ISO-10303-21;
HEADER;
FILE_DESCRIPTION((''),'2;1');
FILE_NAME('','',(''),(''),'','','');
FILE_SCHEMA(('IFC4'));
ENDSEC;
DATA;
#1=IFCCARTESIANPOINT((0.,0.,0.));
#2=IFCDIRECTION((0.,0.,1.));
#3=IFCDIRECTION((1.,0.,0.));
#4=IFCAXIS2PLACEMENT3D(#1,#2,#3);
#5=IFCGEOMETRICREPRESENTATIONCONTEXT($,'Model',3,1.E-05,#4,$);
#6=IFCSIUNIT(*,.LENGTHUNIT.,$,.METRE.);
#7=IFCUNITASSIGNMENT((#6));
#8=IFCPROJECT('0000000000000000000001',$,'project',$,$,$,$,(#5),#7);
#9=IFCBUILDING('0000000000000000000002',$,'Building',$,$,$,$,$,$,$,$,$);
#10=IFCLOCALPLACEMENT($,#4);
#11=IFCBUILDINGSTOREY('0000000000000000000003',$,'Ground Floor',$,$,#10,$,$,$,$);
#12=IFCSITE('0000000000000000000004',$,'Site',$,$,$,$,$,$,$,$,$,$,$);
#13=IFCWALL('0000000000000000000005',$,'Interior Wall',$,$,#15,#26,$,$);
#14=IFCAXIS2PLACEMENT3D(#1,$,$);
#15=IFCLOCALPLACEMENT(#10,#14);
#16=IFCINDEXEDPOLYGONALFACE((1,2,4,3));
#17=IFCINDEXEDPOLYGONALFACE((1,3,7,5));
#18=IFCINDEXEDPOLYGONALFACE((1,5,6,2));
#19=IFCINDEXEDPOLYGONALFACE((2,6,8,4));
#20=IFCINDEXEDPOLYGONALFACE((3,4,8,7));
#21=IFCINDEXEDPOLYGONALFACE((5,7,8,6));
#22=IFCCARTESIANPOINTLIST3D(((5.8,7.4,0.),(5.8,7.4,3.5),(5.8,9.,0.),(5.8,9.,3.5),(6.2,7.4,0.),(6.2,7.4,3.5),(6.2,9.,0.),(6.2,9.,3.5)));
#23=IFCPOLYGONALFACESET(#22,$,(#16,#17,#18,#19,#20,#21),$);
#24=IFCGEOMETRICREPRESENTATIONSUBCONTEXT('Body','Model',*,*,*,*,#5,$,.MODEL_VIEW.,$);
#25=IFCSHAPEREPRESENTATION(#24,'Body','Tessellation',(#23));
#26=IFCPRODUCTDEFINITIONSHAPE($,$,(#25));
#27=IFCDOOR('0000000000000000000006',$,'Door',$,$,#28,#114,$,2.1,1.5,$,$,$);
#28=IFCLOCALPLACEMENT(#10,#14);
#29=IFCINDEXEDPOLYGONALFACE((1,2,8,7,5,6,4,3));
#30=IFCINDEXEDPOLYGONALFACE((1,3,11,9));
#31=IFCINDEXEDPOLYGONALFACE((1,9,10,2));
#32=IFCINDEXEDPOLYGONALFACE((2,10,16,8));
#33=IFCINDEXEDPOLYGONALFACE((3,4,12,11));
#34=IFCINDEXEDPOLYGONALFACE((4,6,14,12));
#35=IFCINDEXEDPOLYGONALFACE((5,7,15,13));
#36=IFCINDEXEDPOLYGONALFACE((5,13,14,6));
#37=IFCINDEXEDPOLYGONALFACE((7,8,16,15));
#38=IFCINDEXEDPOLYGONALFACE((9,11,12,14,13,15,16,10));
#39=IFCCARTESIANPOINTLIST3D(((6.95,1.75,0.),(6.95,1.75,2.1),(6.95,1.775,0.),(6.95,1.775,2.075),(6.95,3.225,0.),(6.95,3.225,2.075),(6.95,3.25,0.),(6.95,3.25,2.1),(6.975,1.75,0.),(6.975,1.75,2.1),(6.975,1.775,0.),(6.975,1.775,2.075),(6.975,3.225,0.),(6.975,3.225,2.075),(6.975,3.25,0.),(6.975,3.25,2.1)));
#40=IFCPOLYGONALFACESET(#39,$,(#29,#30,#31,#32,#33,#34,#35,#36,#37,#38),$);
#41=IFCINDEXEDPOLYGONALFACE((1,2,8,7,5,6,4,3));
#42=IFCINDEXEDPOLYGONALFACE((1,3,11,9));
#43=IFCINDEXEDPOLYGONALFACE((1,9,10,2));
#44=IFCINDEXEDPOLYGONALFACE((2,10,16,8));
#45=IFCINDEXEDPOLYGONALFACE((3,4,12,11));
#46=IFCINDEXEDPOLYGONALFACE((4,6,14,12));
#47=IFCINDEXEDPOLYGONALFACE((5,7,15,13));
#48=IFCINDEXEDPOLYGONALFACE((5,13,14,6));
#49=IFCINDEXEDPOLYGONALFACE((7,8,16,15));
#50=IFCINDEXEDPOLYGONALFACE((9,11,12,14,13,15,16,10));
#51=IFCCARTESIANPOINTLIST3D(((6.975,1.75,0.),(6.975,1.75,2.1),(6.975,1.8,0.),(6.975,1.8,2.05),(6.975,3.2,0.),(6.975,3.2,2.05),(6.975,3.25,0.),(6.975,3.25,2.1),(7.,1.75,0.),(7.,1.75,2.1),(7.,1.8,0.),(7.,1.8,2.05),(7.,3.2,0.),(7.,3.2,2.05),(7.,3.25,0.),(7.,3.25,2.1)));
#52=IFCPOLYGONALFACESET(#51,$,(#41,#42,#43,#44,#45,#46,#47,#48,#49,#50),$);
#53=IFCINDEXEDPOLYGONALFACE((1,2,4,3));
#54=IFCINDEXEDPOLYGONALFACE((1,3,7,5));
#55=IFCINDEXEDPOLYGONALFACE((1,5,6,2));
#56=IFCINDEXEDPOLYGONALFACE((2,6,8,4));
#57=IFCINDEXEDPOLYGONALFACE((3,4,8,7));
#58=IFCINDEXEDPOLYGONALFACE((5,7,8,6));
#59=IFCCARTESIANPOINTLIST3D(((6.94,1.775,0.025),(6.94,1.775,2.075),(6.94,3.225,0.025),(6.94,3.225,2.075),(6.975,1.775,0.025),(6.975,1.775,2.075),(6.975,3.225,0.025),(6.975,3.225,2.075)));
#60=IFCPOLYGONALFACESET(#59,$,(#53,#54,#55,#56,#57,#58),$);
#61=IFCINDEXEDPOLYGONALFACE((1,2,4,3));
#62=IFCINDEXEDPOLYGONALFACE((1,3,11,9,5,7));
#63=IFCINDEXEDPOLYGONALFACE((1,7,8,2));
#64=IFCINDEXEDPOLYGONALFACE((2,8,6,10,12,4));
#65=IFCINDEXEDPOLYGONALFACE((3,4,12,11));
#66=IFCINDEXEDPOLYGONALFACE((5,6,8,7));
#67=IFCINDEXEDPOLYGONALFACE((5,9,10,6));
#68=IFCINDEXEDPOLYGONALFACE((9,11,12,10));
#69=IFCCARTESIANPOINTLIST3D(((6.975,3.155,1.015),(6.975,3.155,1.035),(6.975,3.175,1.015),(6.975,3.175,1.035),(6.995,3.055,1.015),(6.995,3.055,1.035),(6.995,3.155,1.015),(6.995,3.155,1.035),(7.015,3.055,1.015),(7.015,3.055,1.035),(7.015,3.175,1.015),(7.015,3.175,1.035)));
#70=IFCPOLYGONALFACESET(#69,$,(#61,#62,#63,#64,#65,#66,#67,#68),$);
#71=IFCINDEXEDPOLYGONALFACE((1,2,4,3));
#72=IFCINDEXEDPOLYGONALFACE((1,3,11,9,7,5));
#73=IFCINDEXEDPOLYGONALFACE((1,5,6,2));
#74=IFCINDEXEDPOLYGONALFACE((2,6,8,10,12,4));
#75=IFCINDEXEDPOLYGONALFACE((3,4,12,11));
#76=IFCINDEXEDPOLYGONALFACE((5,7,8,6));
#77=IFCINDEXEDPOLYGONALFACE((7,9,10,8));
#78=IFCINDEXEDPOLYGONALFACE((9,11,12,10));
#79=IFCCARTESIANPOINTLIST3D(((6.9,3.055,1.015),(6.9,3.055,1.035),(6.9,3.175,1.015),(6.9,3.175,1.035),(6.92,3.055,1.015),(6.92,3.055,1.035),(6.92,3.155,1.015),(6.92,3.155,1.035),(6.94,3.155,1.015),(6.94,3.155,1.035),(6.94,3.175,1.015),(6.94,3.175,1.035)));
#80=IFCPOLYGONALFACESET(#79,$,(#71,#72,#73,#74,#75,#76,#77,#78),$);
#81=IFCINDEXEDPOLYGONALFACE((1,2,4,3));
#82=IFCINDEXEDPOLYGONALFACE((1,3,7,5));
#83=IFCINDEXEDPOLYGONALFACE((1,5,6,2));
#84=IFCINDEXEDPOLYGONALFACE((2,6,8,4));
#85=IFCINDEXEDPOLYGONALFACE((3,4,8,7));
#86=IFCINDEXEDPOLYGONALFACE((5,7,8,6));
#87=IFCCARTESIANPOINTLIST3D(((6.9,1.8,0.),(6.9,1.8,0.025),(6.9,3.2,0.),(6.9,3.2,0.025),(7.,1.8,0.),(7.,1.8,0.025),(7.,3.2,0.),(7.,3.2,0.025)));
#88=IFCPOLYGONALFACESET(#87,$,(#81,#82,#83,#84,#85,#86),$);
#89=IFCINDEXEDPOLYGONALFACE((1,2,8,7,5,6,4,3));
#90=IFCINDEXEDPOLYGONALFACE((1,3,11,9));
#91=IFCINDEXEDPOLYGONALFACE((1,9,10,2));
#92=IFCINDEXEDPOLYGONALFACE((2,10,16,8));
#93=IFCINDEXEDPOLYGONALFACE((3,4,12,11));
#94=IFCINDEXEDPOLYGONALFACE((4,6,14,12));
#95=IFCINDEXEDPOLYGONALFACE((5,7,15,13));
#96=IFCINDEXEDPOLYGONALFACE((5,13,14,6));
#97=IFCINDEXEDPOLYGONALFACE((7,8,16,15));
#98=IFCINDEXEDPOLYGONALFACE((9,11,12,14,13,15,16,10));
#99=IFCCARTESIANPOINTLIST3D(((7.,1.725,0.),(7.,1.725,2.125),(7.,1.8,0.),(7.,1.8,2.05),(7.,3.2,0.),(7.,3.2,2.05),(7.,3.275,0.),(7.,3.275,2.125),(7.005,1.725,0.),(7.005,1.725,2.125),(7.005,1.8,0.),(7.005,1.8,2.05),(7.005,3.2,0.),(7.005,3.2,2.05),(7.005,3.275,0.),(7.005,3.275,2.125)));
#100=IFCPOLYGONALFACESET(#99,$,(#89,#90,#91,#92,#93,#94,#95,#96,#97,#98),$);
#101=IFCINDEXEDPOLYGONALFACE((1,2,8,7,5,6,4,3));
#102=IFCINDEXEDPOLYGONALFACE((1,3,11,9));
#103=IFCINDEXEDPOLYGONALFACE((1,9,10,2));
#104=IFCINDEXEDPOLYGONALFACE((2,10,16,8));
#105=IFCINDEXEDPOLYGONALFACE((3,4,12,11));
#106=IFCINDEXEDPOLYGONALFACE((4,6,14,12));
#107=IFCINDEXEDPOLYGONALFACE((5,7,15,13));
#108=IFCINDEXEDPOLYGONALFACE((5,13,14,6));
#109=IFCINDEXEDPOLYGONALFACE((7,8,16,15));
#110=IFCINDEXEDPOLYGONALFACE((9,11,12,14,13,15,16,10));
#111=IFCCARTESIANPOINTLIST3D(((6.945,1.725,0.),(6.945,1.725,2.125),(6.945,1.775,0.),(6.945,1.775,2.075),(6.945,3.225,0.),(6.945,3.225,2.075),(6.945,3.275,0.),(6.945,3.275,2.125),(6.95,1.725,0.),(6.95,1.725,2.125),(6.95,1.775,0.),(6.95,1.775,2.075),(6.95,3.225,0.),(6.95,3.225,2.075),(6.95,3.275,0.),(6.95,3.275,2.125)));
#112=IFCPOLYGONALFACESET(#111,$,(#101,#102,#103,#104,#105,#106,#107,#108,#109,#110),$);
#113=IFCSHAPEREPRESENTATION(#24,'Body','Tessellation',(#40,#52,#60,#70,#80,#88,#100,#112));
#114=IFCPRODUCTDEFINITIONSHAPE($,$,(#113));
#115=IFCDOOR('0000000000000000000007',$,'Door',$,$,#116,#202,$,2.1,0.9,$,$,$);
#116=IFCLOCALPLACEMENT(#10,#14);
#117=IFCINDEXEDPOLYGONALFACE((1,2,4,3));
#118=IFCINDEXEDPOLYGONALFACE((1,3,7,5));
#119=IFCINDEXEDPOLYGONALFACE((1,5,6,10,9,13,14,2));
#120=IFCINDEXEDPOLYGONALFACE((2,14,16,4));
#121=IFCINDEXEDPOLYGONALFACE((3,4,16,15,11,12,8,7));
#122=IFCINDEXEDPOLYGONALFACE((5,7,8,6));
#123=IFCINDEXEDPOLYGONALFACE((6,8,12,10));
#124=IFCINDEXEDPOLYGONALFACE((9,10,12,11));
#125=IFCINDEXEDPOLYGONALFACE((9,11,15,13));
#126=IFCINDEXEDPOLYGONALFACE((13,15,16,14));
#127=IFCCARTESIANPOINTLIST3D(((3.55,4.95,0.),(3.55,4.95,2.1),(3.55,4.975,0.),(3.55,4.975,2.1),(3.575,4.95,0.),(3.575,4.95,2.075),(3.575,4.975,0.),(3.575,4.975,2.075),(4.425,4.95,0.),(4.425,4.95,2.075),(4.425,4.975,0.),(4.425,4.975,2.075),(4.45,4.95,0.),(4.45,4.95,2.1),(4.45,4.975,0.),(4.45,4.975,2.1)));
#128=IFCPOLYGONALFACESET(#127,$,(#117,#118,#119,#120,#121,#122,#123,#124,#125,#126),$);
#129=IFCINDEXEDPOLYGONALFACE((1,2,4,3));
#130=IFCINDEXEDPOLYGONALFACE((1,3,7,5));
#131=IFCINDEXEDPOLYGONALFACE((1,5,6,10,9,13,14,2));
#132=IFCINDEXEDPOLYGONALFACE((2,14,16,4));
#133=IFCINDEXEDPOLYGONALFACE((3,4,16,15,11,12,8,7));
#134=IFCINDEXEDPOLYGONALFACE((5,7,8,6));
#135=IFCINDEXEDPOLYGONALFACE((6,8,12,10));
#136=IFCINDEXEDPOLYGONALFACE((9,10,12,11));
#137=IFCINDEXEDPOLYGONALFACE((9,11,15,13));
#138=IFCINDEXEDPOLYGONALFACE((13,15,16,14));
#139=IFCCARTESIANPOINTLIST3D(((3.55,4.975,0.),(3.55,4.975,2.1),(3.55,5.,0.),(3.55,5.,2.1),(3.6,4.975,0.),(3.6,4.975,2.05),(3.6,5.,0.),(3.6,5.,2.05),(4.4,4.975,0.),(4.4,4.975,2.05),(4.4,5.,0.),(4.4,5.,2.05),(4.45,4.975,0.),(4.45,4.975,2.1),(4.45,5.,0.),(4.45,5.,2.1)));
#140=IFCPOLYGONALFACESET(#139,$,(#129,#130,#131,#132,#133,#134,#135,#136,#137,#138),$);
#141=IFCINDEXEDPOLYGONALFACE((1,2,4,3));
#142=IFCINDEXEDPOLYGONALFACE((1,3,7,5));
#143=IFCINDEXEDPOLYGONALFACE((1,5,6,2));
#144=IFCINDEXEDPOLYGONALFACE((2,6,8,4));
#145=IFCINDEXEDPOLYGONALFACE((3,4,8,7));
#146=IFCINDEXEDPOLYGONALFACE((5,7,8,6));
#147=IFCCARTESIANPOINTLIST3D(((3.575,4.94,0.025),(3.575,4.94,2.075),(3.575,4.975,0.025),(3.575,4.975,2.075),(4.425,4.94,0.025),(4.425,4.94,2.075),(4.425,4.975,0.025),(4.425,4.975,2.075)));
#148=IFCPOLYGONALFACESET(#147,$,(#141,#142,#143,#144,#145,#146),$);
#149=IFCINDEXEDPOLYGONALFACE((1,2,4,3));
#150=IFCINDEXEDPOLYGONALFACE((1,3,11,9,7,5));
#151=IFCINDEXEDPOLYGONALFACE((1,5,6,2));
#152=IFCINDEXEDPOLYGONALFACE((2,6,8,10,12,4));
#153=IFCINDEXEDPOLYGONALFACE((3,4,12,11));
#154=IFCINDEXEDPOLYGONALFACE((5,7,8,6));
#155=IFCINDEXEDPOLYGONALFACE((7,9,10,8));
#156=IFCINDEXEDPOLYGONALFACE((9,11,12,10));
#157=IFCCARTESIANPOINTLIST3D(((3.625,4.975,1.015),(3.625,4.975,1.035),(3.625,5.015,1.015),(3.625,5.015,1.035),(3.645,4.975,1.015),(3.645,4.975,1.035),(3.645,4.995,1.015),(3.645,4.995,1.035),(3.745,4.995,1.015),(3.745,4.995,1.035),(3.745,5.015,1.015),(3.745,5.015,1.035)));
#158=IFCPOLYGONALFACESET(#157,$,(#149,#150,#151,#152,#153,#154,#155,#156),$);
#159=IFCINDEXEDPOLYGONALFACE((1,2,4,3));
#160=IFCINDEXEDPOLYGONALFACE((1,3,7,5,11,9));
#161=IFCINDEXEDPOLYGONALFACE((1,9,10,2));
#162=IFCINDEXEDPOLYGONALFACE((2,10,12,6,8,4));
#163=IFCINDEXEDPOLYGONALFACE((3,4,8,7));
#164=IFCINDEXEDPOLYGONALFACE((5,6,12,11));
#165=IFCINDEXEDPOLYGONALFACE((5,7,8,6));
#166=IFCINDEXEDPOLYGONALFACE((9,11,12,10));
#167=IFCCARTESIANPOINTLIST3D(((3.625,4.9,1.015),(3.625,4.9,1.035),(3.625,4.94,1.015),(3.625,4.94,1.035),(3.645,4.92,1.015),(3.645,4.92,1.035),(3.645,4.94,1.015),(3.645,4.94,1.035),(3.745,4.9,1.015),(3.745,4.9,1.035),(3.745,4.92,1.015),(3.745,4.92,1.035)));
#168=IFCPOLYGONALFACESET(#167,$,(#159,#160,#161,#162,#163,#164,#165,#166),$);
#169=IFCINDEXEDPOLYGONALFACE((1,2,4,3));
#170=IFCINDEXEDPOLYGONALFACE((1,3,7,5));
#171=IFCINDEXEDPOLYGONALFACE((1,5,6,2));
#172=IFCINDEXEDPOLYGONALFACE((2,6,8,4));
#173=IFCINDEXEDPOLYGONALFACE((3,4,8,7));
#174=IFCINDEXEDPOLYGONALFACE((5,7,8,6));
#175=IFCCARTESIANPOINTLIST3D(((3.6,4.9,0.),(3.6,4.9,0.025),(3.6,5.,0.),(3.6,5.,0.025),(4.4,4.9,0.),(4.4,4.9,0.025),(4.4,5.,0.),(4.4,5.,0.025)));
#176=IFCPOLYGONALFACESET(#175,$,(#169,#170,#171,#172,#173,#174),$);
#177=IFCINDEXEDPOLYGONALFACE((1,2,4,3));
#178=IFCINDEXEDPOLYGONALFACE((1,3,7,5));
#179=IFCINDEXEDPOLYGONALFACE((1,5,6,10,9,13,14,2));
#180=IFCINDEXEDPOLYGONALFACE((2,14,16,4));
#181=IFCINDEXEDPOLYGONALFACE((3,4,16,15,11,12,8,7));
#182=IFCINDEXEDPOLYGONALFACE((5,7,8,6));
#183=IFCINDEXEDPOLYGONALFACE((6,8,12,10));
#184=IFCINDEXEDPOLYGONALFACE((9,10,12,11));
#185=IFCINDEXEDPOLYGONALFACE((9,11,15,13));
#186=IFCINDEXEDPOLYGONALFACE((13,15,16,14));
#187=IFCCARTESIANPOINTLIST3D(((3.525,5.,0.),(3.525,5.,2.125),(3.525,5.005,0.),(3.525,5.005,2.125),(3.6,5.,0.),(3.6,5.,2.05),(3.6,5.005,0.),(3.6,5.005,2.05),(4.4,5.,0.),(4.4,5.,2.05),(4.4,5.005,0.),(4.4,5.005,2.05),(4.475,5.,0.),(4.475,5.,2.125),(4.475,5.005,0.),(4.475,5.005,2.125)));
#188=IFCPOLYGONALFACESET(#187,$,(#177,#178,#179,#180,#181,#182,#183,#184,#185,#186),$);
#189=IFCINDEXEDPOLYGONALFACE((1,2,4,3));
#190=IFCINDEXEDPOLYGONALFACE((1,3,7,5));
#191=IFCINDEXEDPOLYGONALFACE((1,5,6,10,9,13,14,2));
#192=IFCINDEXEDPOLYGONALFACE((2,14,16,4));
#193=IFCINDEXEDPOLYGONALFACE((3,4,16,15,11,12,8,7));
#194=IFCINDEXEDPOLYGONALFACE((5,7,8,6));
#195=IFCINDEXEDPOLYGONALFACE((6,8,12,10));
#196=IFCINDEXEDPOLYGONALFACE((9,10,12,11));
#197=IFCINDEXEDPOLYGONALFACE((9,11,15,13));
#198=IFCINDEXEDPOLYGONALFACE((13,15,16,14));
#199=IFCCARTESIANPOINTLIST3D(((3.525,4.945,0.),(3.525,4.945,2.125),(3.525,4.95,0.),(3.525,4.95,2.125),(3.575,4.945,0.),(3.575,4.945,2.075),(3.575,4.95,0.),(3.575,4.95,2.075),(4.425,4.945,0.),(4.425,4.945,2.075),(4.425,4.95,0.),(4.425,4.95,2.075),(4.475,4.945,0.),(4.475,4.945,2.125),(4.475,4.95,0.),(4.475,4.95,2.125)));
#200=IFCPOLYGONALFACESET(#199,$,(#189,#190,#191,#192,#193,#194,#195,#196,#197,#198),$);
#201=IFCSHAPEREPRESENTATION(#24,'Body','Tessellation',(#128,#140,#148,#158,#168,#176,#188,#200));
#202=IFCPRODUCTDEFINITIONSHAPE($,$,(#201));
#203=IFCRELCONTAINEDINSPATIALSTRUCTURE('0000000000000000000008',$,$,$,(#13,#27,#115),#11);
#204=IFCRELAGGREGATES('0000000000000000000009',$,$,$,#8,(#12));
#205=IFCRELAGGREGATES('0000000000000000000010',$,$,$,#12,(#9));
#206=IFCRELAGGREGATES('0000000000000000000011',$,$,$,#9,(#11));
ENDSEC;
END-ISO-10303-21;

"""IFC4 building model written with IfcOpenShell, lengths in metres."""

from ifc_helpers import new_model, si_unit, frame, origin_with_axes, place, context, subcontext, project, spatial, line, indexed_curve, outline, extrude, element, save


model = new_model("IFC4")

# Units and contexts
model_context = context("Model", 3, precision=1e-05, world=origin_with_axes())
body_context = subcontext(model_context, "Body", "Model", "MODEL_VIEW")
ifc_project = project(units=[si_unit("LENGTHUNIT", "METRE")], contexts=[model_context])

# Site, building, storey
site = spatial("IfcSite", under=ifc_project, Name="Site")
building = spatial("IfcBuilding", under=site, Name="Building")
storey_placement = place(None, origin_with_axes())
storey = spatial("IfcBuildingStorey", under=building, at=storey_placement, Name="Ground Floor")

# Wall
for number, where, z_axis, x_axis, name in (
    (1, (6.0, 7.4, 0.0), (0.0, 0.0, 1.0), (0.0, 1.0, 0.0), "Interior Wall"),
):
    element("IfcWall", number, at=place(storey_placement, frame(where, z_axis=z_axis, x_axis=x_axis)), inside=storey, Name=name, context=body_context, shape_type="SweptSolid", body=[
        extrude(outline(indexed_curve([(0.0, 0.0), (0.0, 0.4), (1.6, 0.4), (1.6, 0.0), (0.0, 0.0)], self_intersect=False)), frame((0.0, -0.2, 0.0), z_axis=(0.0, 0.0, 1.0), x_axis=(1.0, 0.0, 0.0)), (0.0, 0.0, 1.0), 3.5),
    ])

# Doors
door_1_placement = place(storey_placement, frame((7.0, 1.75, 0.0), z_axis=(0.0, 0.0, 1.0), x_axis=(0.0, 1.0, 0.0)))
element("IfcDoor", 2, at=door_1_placement, inside=storey, Name="Door", OverallHeight=2.1, OverallWidth=1.5, context=body_context, shape_type="SweptSolid", body=[
    extrude(outline(indexed_curve([(0.0, 0.0), (0.0, 2.1), (1.5, 2.1), (1.5, 0.0), (1.475, 0.0), (1.475, 2.075), (0.025, 2.075), (0.025, 0.0)], segments=[line(1, 2, 3, 4, 5, 6, 7, 8, 1)])), frame((0.0, 0.025, 0.0), z_axis=(0.0, -1.0, 0.0), x_axis=(1.0, 0.0, 0.0)), (0.0, 0.0, -1.0), 0.025),
    extrude(outline(indexed_curve([(0.0, 0.0), (0.0, 2.1), (1.5, 2.1), (1.5, 0.0), (1.45, 0.0), (1.45, 2.05), (0.05, 2.05), (0.05, 0.0)], segments=[line(1, 2, 3, 4, 5, 6, 7, 8, 1)])), frame((0.0, 0.0, 0.0), z_axis=(0.0, -1.0, 0.0), x_axis=(1.0, 0.0, 0.0)), (0.0, 0.0, -1.0), 0.025),
    extrude(outline(indexed_curve([(0.0, 0.0), (1.45, 0.0), (1.45, 0.035), (0.0, 0.035)], segments=[line(1, 2, 3, 4, 1)])), frame((0.025, 0.025, 0.025), z_axis=(0.0, 0.0, 1.0), x_axis=(1.0, 0.0, 0.0)), (0.0, 0.0, 1.0), 2.05),
    extrude(outline(indexed_curve([(0.0, 0.0), (0.0, -0.04), (-0.12, -0.04), (-0.12, -0.02), (-0.02, -0.02), (-0.02, 0.0)], segments=[line(1, 2, 3, 4, 5, 6, 1)])), frame((1.425, 0.025, 1.015), z_axis=(0.0, 0.0, 1.0), x_axis=(1.0, 0.0, 0.0)), (0.0, 0.0, 1.0), 0.02),
    extrude(outline(indexed_curve([(0.0, 0.0), (0.0, 0.04), (-0.12, 0.04), (-0.12, 0.02), (-0.02, 0.02), (-0.02, 0.0)], segments=[line(1, 2, 3, 4, 5, 6, 1)])), frame((1.425, 0.06, 1.015), z_axis=(0.0, 0.0, 1.0), x_axis=(1.0, 0.0, 0.0)), (0.0, 0.0, 1.0), 0.02),
    extrude(outline(indexed_curve([(0.0, 0.0), (1.4, 0.0), (1.4, 0.1), (0.0, 0.1)], segments=[line(1, 2, 3, 4, 1)])), frame((0.05, 0.0, 0.0), z_axis=(0.0, 0.0, 1.0), x_axis=(1.0, 0.0, 0.0)), (0.0, 0.0, 1.0), 0.025),
    extrude(outline(indexed_curve([(0.0, 0.0), (0.0, 2.125), (1.55, 2.125), (1.55, 0.0), (1.475, 0.0), (1.475, 2.05), (0.075, 2.05), (0.075, 0.0)], segments=[line(1, 2, 3, 4, 5, 6, 7, 8, 1)])), frame((-0.025, -0.005, 0.0), z_axis=(0.0, -1.0, 0.0), x_axis=(1.0, 0.0, 0.0)), (0.0, 0.0, -1.0), 0.005),
    extrude(outline(indexed_curve([(0.0, 0.0), (0.0, 2.125), (1.55, 2.125), (1.55, 0.0), (1.5, 0.0), (1.5, 2.075), (0.05, 2.075), (0.05, 0.0)], segments=[line(1, 2, 3, 4, 5, 6, 7, 8, 1)])), frame((-0.025, 0.05, 0.0), z_axis=(0.0, -1.0, 0.0), x_axis=(1.0, 0.0, 0.0)), (0.0, 0.0, -1.0), 0.005),
])
door_2_placement = place(storey_placement, frame((4.45, 5.0, 0.0), z_axis=(0.0, 0.0, 1.0), x_axis=(-1.0, 0.0, 0.0)))
element("IfcDoor", 3, at=door_2_placement, inside=storey, Name="Door", OverallHeight=2.1, OverallWidth=0.9, context=body_context, shape_type="SweptSolid", body=[
    extrude(outline(indexed_curve([(0.0, 0.0), (0.0, 2.1), (0.9, 2.1), (0.9, 0.0), (0.875, 0.0), (0.875, 2.075), (0.025, 2.075), (0.025, 0.0)], segments=[line(1, 2, 3, 4, 5, 6, 7, 8, 1)])), frame((0.0, 0.025, 0.0), z_axis=(0.0, -1.0, 0.0), x_axis=(1.0, 0.0, 0.0)), (0.0, 0.0, -1.0), 0.025),
    extrude(outline(indexed_curve([(0.0, 0.0), (0.0, 2.1), (0.9, 2.1), (0.9, 0.0), (0.85, 0.0), (0.85, 2.05), (0.05, 2.05), (0.05, 0.0)], segments=[line(1, 2, 3, 4, 5, 6, 7, 8, 1)])), frame((0.0, 0.0, 0.0), z_axis=(0.0, -1.0, 0.0), x_axis=(1.0, 0.0, 0.0)), (0.0, 0.0, -1.0), 0.025),
    extrude(outline(indexed_curve([(0.0, 0.0), (0.85, 0.0), (0.85, 0.035), (0.0, 0.035)], segments=[line(1, 2, 3, 4, 1)])), frame((0.025, 0.025, 0.025), z_axis=(0.0, 0.0, 1.0), x_axis=(1.0, 0.0, 0.0)), (0.0, 0.0, 1.0), 2.05),
    extrude(outline(indexed_curve([(0.0, 0.0), (0.0, -0.04), (-0.12, -0.04), (-0.12, -0.02), (-0.02, -0.02), (-0.02, 0.0)], segments=[line(1, 2, 3, 4, 5, 6, 1)])), frame((0.825, 0.025, 1.015), z_axis=(0.0, 0.0, 1.0), x_axis=(1.0, 0.0, 0.0)), (0.0, 0.0, 1.0), 0.02),
    extrude(outline(indexed_curve([(0.0, 0.0), (0.0, 0.04), (-0.12, 0.04), (-0.12, 0.02), (-0.02, 0.02), (-0.02, 0.0)], segments=[line(1, 2, 3, 4, 5, 6, 1)])), frame((0.825, 0.06, 1.015), z_axis=(0.0, 0.0, 1.0), x_axis=(1.0, 0.0, 0.0)), (0.0, 0.0, 1.0), 0.02),
    extrude(outline(indexed_curve([(0.0, 0.0), (0.8, 0.0), (0.8, 0.1), (0.0, 0.1)], segments=[line(1, 2, 3, 4, 1)])), frame((0.05, 0.0, 0.0), z_axis=(0.0, 0.0, 1.0), x_axis=(1.0, 0.0, 0.0)), (0.0, 0.0, 1.0), 0.025),
    extrude(outline(indexed_curve([(0.0, 0.0), (0.0, 2.125), (0.95, 2.125), (0.95, 0.0), (0.875, 0.0), (0.875, 2.05), (0.075, 2.05), (0.075, 0.0)], segments=[line(1, 2, 3, 4, 5, 6, 7, 8, 1)])), frame((-0.025, -0.005, 0.0), z_axis=(0.0, -1.0, 0.0), x_axis=(1.0, 0.0, 0.0)), (0.0, 0.0, -1.0), 0.005),
    extrude(outline(indexed_curve([(0.0, 0.0), (0.0, 2.125), (0.95, 2.125), (0.95, 0.0), (0.9, 0.0), (0.9, 2.075), (0.05, 2.075), (0.05, 0.0)], segments=[line(1, 2, 3, 4, 5, 6, 7, 8, 1)])), frame((-0.025, 0.05, 0.0), z_axis=(0.0, -1.0, 0.0), x_axis=(1.0, 0.0, 0.0)), (0.0, 0.0, -1.0), 0.005),
])

save(model, "model.ifc")
